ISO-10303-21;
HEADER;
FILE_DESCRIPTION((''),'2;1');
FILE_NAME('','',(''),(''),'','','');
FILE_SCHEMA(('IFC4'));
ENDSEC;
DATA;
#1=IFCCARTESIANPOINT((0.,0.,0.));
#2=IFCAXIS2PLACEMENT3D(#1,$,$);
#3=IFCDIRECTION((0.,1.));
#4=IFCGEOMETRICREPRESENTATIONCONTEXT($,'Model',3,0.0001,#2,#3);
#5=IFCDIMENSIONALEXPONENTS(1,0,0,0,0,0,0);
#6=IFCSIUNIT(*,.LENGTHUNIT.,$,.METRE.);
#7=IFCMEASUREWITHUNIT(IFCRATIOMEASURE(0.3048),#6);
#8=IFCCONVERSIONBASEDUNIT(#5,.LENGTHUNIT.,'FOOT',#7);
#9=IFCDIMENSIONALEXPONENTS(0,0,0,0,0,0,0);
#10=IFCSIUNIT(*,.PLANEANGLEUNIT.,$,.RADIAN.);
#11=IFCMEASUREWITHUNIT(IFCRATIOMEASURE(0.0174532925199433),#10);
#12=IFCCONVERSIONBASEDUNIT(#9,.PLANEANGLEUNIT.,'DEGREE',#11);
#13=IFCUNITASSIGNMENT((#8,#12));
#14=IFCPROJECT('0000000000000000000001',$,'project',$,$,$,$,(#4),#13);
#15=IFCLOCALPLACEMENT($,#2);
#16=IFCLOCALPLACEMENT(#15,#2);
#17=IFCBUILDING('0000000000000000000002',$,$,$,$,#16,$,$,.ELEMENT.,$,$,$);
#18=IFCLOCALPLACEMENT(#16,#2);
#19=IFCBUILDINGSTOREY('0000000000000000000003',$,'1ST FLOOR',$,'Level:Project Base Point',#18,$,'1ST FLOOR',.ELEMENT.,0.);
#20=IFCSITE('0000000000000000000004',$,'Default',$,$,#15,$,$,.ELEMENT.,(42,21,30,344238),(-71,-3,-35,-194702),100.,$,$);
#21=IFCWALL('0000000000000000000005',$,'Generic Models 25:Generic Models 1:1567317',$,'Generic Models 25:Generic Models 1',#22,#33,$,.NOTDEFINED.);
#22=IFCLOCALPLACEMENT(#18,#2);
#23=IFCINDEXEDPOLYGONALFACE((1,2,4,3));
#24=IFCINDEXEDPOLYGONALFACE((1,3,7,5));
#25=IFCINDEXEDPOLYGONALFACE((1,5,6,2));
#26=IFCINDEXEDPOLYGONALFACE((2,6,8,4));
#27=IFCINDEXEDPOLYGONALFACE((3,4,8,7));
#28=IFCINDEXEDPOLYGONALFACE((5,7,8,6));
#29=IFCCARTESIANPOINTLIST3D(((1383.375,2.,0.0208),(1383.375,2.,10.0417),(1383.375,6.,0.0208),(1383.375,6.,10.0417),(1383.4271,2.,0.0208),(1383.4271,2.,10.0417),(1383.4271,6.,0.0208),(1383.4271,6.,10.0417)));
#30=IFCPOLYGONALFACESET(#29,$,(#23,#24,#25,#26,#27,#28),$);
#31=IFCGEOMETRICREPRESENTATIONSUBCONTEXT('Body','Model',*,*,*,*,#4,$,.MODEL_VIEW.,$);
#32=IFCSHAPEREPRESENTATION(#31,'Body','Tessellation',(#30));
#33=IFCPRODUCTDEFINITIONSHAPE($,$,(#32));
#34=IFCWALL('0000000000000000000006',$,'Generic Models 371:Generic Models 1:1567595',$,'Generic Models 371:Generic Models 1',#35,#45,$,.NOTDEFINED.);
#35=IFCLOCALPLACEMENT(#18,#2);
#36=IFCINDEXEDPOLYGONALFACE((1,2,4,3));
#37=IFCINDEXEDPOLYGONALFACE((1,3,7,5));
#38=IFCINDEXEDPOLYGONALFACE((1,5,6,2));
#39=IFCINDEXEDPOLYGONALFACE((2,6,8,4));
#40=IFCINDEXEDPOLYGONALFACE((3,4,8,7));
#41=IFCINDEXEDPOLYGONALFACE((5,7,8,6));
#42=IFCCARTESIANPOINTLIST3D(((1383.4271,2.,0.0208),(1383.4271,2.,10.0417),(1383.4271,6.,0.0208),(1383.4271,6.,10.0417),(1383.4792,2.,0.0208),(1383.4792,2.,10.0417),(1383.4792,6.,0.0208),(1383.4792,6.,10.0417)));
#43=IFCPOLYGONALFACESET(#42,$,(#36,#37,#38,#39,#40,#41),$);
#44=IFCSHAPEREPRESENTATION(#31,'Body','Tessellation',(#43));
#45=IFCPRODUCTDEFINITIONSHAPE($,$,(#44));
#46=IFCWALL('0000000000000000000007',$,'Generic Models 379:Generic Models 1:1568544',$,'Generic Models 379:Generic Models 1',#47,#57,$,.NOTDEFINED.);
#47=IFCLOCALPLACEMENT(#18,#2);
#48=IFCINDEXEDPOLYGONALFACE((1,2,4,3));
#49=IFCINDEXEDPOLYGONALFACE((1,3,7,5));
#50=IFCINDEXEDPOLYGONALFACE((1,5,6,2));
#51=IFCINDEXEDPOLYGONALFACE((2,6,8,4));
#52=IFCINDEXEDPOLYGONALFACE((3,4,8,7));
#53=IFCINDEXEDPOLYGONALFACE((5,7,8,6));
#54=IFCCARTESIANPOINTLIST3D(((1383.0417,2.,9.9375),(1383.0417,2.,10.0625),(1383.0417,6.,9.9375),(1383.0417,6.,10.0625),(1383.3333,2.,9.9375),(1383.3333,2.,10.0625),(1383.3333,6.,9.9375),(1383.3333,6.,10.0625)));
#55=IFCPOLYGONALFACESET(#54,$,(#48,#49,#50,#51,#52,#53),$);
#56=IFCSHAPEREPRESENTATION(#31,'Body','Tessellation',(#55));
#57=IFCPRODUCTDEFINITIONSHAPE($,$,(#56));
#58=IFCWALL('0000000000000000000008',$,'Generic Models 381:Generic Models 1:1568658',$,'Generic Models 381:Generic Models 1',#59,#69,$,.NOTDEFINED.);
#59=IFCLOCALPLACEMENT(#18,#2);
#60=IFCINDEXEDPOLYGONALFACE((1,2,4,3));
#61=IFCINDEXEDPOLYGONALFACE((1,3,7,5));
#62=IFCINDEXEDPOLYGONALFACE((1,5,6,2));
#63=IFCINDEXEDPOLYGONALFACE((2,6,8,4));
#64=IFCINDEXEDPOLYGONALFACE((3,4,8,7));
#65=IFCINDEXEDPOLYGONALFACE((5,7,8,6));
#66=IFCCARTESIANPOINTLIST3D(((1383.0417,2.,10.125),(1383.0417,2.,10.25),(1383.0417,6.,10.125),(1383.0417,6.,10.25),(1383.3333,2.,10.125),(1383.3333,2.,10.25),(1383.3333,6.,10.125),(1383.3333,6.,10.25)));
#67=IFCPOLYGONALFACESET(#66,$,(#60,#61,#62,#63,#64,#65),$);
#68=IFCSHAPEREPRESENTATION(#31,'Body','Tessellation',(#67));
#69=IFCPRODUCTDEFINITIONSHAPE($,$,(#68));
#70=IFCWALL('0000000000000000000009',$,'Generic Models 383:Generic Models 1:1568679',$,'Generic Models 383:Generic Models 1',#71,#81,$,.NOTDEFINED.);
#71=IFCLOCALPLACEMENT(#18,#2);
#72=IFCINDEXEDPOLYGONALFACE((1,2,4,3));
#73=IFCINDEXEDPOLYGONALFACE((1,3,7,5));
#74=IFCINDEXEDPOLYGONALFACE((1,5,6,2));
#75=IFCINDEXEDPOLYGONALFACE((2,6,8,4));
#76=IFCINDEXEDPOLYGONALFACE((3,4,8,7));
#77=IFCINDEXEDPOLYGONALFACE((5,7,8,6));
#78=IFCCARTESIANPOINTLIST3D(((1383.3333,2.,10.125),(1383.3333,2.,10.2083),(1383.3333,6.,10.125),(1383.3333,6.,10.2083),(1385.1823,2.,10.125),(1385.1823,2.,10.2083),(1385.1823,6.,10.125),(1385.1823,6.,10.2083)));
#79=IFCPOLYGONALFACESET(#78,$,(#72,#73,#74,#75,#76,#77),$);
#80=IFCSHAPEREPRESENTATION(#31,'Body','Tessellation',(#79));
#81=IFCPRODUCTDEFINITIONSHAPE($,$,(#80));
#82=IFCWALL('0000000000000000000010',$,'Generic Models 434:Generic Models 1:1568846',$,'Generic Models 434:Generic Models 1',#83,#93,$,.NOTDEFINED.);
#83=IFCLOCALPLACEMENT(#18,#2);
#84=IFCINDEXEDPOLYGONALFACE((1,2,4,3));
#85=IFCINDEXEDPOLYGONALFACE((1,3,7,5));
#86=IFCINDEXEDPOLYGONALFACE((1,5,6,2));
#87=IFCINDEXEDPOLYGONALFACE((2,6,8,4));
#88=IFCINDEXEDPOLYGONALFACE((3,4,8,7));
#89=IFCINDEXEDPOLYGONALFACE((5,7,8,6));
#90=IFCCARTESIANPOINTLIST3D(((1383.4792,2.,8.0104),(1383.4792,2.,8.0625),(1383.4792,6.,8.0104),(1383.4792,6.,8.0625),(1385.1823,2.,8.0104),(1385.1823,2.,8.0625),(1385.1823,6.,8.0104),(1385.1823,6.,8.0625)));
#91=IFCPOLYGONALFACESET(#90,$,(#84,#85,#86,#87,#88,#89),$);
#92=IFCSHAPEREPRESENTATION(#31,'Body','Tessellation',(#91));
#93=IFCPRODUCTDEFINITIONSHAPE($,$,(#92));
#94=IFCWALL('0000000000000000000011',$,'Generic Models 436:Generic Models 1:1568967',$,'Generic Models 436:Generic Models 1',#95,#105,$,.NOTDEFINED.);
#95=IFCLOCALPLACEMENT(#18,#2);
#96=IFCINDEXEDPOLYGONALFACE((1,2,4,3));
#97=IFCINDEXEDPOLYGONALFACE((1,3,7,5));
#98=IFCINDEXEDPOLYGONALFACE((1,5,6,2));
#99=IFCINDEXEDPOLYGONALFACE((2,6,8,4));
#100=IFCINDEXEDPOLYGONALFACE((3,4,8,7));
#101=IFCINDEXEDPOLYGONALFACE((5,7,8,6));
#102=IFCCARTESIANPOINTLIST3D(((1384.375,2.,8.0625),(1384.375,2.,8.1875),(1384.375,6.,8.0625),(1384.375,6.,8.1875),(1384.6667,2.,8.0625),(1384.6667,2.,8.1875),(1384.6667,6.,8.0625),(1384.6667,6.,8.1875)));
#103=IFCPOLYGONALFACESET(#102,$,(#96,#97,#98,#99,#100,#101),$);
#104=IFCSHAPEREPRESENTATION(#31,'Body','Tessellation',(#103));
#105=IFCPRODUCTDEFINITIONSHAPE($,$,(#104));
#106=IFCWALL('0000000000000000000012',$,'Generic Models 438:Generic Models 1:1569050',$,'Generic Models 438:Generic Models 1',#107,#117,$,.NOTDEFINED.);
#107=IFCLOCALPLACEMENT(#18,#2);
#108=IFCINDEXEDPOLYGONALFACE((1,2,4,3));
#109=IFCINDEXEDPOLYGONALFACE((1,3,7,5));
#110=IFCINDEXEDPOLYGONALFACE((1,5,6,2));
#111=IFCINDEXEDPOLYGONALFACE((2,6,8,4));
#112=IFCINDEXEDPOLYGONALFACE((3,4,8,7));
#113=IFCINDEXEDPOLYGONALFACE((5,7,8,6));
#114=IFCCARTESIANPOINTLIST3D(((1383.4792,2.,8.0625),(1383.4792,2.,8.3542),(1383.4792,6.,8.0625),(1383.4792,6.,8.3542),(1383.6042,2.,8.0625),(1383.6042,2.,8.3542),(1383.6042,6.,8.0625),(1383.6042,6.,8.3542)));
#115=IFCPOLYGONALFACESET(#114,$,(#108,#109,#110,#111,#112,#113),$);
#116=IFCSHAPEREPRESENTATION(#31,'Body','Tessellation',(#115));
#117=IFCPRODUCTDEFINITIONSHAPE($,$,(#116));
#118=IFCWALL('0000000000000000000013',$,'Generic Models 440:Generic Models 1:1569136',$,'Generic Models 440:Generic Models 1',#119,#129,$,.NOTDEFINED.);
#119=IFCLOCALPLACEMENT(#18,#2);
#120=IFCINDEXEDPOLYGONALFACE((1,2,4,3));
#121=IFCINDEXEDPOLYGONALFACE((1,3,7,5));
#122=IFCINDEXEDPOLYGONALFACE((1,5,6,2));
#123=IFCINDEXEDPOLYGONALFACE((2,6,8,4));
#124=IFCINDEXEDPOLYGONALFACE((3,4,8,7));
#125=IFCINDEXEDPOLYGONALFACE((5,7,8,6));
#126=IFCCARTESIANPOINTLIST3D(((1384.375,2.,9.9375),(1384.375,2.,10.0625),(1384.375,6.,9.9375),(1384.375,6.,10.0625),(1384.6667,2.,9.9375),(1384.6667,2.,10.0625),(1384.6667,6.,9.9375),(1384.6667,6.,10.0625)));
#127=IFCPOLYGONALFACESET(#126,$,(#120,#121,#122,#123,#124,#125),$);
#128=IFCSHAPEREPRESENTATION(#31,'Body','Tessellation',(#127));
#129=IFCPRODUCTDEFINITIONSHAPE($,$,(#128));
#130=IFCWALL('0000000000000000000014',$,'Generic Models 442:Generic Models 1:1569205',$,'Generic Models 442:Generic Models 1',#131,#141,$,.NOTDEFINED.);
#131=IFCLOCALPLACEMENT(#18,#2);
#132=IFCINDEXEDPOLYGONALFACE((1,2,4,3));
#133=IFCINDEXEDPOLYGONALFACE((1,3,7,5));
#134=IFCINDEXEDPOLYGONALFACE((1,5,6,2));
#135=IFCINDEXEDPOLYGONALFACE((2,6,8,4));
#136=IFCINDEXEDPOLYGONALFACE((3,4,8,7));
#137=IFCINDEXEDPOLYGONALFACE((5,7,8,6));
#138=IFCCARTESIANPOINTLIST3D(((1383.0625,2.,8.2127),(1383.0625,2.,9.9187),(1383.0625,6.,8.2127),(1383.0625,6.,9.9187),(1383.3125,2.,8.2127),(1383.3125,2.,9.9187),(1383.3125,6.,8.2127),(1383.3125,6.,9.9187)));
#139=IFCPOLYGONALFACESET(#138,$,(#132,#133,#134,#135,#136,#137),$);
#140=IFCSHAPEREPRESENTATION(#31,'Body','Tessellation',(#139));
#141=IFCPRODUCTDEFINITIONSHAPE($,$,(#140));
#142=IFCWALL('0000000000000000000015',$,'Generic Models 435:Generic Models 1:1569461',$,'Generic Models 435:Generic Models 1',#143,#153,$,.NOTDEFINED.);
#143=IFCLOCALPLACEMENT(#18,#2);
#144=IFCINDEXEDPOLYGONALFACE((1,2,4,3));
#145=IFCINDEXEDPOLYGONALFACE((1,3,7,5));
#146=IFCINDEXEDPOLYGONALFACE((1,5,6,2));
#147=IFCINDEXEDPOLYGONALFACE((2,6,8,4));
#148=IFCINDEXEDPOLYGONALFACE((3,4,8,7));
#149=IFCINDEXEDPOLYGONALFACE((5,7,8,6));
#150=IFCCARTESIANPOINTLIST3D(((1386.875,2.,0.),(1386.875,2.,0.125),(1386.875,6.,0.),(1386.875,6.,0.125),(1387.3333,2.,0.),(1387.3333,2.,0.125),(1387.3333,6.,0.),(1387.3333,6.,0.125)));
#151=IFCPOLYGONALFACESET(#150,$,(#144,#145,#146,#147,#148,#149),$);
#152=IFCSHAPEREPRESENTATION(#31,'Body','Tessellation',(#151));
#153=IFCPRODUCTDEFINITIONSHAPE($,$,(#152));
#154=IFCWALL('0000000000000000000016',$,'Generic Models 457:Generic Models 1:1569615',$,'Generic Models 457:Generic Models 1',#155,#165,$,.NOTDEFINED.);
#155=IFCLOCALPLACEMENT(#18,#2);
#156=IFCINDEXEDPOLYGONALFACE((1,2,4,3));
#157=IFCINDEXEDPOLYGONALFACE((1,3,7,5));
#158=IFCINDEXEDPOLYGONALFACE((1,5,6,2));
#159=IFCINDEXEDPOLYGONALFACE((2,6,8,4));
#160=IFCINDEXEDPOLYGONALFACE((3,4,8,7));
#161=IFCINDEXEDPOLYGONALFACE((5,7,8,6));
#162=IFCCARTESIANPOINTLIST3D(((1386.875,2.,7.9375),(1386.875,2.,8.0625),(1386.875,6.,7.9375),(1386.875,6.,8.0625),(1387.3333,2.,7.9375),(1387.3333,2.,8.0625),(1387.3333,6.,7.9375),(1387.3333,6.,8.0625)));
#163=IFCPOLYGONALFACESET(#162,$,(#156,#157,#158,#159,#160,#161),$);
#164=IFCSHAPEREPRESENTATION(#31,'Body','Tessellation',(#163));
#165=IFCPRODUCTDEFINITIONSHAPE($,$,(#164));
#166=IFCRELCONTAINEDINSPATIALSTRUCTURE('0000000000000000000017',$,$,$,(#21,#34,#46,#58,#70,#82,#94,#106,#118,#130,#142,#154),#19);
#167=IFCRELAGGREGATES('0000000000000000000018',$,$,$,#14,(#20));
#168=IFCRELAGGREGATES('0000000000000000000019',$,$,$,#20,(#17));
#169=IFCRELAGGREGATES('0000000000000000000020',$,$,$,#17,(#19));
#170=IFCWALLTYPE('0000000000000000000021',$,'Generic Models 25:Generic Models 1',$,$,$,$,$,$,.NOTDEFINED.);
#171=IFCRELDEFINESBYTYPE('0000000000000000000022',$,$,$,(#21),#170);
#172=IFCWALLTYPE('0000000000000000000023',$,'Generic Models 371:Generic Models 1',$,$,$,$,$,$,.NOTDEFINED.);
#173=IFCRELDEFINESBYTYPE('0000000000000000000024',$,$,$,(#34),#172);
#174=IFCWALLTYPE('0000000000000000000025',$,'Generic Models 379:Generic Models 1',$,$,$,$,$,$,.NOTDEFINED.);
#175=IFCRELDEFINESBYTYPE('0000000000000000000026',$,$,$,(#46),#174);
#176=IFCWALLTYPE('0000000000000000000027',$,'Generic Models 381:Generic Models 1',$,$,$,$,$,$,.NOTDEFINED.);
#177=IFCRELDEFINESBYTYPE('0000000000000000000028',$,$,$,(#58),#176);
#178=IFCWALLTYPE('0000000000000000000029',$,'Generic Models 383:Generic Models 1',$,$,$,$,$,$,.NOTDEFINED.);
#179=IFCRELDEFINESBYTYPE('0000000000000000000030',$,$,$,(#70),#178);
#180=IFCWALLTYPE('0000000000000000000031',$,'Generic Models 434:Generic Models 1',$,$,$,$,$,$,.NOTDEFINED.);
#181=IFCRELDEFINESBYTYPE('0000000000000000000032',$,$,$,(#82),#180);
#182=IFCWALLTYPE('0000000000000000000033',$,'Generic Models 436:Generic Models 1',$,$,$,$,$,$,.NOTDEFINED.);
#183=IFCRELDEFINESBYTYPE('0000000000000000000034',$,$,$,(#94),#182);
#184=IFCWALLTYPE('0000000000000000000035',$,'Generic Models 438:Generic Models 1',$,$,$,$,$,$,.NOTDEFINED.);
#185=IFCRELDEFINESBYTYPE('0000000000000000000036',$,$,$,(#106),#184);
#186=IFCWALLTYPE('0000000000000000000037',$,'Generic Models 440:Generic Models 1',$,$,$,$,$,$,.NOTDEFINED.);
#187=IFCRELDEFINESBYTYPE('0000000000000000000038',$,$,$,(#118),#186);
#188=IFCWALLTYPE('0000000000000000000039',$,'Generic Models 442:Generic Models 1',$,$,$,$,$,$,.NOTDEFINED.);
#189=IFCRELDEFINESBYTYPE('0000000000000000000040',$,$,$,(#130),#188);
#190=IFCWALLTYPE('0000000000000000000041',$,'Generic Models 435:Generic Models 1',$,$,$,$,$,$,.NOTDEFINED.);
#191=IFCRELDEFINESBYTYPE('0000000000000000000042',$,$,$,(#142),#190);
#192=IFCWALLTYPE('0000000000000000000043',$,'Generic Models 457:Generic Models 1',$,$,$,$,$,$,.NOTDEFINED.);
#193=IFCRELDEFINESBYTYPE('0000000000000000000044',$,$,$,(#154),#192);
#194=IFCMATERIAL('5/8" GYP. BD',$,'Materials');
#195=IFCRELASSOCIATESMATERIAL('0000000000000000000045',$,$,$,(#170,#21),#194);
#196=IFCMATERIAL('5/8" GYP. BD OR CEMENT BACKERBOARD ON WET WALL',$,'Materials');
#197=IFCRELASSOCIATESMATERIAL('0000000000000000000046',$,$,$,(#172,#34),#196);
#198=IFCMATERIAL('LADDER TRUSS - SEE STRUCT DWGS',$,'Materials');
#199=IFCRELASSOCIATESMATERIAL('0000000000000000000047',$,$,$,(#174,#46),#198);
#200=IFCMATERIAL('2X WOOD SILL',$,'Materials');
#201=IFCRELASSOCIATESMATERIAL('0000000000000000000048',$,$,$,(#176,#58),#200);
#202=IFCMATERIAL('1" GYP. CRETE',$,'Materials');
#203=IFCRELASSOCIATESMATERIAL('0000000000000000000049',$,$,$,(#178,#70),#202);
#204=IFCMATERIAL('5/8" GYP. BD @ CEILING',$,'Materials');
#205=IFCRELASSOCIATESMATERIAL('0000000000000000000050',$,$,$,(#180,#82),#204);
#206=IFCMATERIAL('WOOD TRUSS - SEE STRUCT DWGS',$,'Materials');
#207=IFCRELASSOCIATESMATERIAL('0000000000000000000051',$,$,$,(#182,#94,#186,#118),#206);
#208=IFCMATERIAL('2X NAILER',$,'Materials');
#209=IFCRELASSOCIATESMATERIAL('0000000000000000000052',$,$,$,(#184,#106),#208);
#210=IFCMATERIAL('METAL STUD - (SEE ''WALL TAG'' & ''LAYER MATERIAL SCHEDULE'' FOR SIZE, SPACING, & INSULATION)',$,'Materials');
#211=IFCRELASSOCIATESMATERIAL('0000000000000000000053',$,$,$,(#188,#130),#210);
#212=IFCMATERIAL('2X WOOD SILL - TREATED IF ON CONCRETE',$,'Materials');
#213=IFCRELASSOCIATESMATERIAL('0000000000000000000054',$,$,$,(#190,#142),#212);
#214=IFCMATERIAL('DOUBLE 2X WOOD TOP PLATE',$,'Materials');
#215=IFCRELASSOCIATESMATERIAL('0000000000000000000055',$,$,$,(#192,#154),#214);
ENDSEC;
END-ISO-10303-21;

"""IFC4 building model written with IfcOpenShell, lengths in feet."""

from ifc_helpers import new_model, entity, si_unit, converted_unit, direction, frame, frame_2d, origin, origin_2d_with_axis, place, context, subcontext, project, spatial, rectangle, extrude, material, type_object, element, save


model = new_model("IFC4")

# Units and contexts
model_context = context("Model", 3, precision=0.0001, world=origin(), true_north=direction((0.0, 1.0)))
body_context = subcontext(model_context, "Body", "Model", "MODEL_VIEW")
ifc_project = project(units=[converted_unit("LENGTHUNIT", "FOOT", entity("IfcRatioMeasure", 0.3048), si_unit("LENGTHUNIT", "METRE"), dimensions=[1, 0, 0, 0, 0, 0, 0]), converted_unit("PLANEANGLEUNIT", "DEGREE", entity("IfcRatioMeasure", 0.0174532925199433), si_unit("PLANEANGLEUNIT", "RADIAN"), dimensions=[0, 0, 0, 0, 0, 0, 0])], contexts=[model_context])

# Site, building, storey
site_placement = place(None, origin())
site = spatial("IfcSite", under=ifc_project, at=site_placement, Name="Default", CompositionType="ELEMENT", RefLatitude=(42, 21, 30, 344238), RefLongitude=(-71, -3, -35, -194702), RefElevation=100.0)
building_placement = place(site_placement, origin())
building = spatial("IfcBuilding", under=site, at=building_placement, CompositionType="ELEMENT")
storey_placement = place(building_placement, origin())
storey = spatial("IfcBuildingStorey", under=building, at=storey_placement, Name="1ST FLOOR", ObjectType="Level:Project Base Point", LongName="1ST FLOOR", CompositionType="ELEMENT", Elevation=0.0)

# Walls
ifc_material_1 = material(Name="5/8\" GYP. BD", Category="Materials")
wall_type_1 = type_object("IfcWallType", Name="Generic Models 25:Generic Models 1", PredefinedType="NOTDEFINED", material=ifc_material_1)
wall_1_placement = place(storey_placement, frame((1383.375, 2.0, 0.0208), z_axis=(0.0, 0.0, 1.0), x_axis=(0.0, 1.0, 0.0)))
element("IfcWall", 1, at=wall_1_placement, inside=storey, type_object=wall_type_1, material=ifc_material_1, Name="Generic Models 25:Generic Models 1:1567317", ObjectType="Generic Models 25:Generic Models 1", PredefinedType="NOTDEFINED", context=body_context, shape_type="SweptSolid", body=[
    extrude(rectangle(XDim=4.0, YDim=0.0521, at=origin_2d_with_axis()), frame((2.0, -0.026, 0.0)), (0.0, 0.0, 1.0), 10.0208),
])
ifc_material_2 = material(Name="5/8\" GYP. BD OR CEMENT BACKERBOARD ON WET WALL", Category="Materials")
wall_type_2 = type_object("IfcWallType", Name="Generic Models 371:Generic Models 1", PredefinedType="NOTDEFINED", material=ifc_material_2)
wall_2_placement = place(storey_placement, frame((1383.4271, 2.0, 0.0208), z_axis=(0.0, 0.0, 1.0), x_axis=(0.0, 1.0, 0.0)))
element("IfcWall", 2, at=wall_2_placement, inside=storey, type_object=wall_type_2, material=ifc_material_2, Name="Generic Models 371:Generic Models 1:1567595", ObjectType="Generic Models 371:Generic Models 1", PredefinedType="NOTDEFINED", context=body_context, shape_type="SweptSolid", body=[
    extrude(rectangle(XDim=4.0, YDim=0.0521, at=frame_2d((0.0, 0.0), x_axis=(1.0, 0.0))), frame((2.0, -0.026, 0.0)), (0.0, 0.0, 1.0), 10.0208),
])
ifc_material_3 = material(Name="LADDER TRUSS - SEE STRUCT DWGS", Category="Materials")
wall_type_3 = type_object("IfcWallType", Name="Generic Models 379:Generic Models 1", PredefinedType="NOTDEFINED", material=ifc_material_3)
wall_3_placement = place(storey_placement, frame((1383.0417, 2.0, 9.9375), z_axis=(0.0, 0.0, 1.0), x_axis=(0.0, 1.0, 0.0)))
element("IfcWall", 3, at=wall_3_placement, inside=storey, type_object=wall_type_3, material=ifc_material_3, Name="Generic Models 379:Generic Models 1:1568544", ObjectType="Generic Models 379:Generic Models 1", PredefinedType="NOTDEFINED", context=body_context, shape_type="SweptSolid", body=[
    extrude(rectangle(XDim=4.0, YDim=0.2917, at=origin_2d_with_axis()), frame((2.0, -0.1458, 0.0)), (0.0, 0.0, 1.0), 0.125),
])
ifc_material_4 = material(Name="2X WOOD SILL", Category="Materials")
wall_type_4 = type_object("IfcWallType", Name="Generic Models 381:Generic Models 1", PredefinedType="NOTDEFINED", material=ifc_material_4)
wall_4_placement = place(storey_placement, frame((1383.0417, 2.0, 10.125), z_axis=(0.0, 0.0, 1.0), x_axis=(0.0, 1.0, 0.0)))
element("IfcWall", 4, at=wall_4_placement, inside=storey, type_object=wall_type_4, material=ifc_material_4, Name="Generic Models 381:Generic Models 1:1568658", ObjectType="Generic Models 381:Generic Models 1", PredefinedType="NOTDEFINED", context=body_context, shape_type="SweptSolid", body=[
    extrude(rectangle(XDim=4.0, YDim=0.2917, at=frame_2d((0.0, 0.0), x_axis=(1.0, 0.0))), frame((2.0, -0.1458, 0.0)), (0.0, 0.0, 1.0), 0.125),
])
ifc_material_5 = material(Name="1\" GYP. CRETE", Category="Materials")
wall_type_5 = type_object("IfcWallType", Name="Generic Models 383:Generic Models 1", PredefinedType="NOTDEFINED", material=ifc_material_5)
wall_5_placement = place(storey_placement, frame((1383.3333, 2.0, 10.125), z_axis=(0.0, 0.0, 1.0), x_axis=(0.0, 1.0, 0.0)))
element("IfcWall", 5, at=wall_5_placement, inside=storey, type_object=wall_type_5, material=ifc_material_5, Name="Generic Models 383:Generic Models 1:1568679", ObjectType="Generic Models 383:Generic Models 1", PredefinedType="NOTDEFINED", context=body_context, shape_type="SweptSolid", body=[
    extrude(rectangle(XDim=4.0, YDim=1.849, at=frame_2d((0.0, 0.0), x_axis=(1.0, 0.0))), frame((2.0, -0.9245, 0.0)), (0.0, 0.0, 1.0), 0.0833),
])
ifc_material_6 = material(Name="5/8\" GYP. BD @ CEILING", Category="Materials")
wall_type_6 = type_object("IfcWallType", Name="Generic Models 434:Generic Models 1", PredefinedType="NOTDEFINED", material=ifc_material_6)
wall_6_placement = place(storey_placement, frame((1383.4792, 2.0, 8.0104), z_axis=(0.0, 0.0, 1.0), x_axis=(0.0, 1.0, 0.0)))
element("IfcWall", 6, at=wall_6_placement, inside=storey, type_object=wall_type_6, material=ifc_material_6, Name="Generic Models 434:Generic Models 1:1568846", ObjectType="Generic Models 434:Generic Models 1", PredefinedType="NOTDEFINED", context=body_context, shape_type="SweptSolid", body=[
    extrude(rectangle(XDim=4.0, YDim=1.7031, at=frame_2d((0.0, 0.0), x_axis=(1.0, 0.0))), frame((2.0, -0.8516, 0.0)), (0.0, 0.0, 1.0), 0.0521),
])
ifc_material_7 = material(Name="WOOD TRUSS - SEE STRUCT DWGS", Category="Materials")
wall_type_7 = type_object("IfcWallType", Name="Generic Models 436:Generic Models 1", PredefinedType="NOTDEFINED", material=ifc_material_7)
wall_7_placement = place(storey_placement, frame((1384.375, 2.0, 8.0625), z_axis=(0.0, 0.0, 1.0), x_axis=(0.0, 1.0, 0.0)))
element("IfcWall", 7, at=wall_7_placement, inside=storey, type_object=wall_type_7, material=ifc_material_7, Name="Generic Models 436:Generic Models 1:1568967", ObjectType="Generic Models 436:Generic Models 1", PredefinedType="NOTDEFINED", context=body_context, shape_type="SweptSolid", body=[
    extrude(rectangle(XDim=4.0, YDim=0.2917, at=frame_2d((0.0, 0.0), x_axis=(1.0, 0.0))), frame((2.0, -0.1458, 0.0)), (0.0, 0.0, 1.0), 0.125),
])
ifc_material_8 = material(Name="2X NAILER", Category="Materials")
wall_type_8 = type_object("IfcWallType", Name="Generic Models 438:Generic Models 1", PredefinedType="NOTDEFINED", material=ifc_material_8)
wall_8_placement = place(storey_placement, frame((1383.4792, 2.0, 8.0625), z_axis=(0.0, 0.0, 1.0), x_axis=(0.0, 1.0, 0.0)))
element("IfcWall", 8, at=wall_8_placement, inside=storey, type_object=wall_type_8, material=ifc_material_8, Name="Generic Models 438:Generic Models 1:1569050", ObjectType="Generic Models 438:Generic Models 1", PredefinedType="NOTDEFINED", context=body_context, shape_type="SweptSolid", body=[
    extrude(rectangle(XDim=4.0, YDim=0.125, at=frame_2d((0.0, 0.0), x_axis=(1.0, 0.0))), frame((2.0, -0.0625, 0.0)), (0.0, 0.0, 1.0), 0.2917),
])
wall_type_9 = type_object("IfcWallType", Name="Generic Models 440:Generic Models 1", PredefinedType="NOTDEFINED", material=ifc_material_7)
wall_9_placement = place(storey_placement, frame((1384.375, 2.0, 9.9375), z_axis=(0.0, 0.0, 1.0), x_axis=(0.0, 1.0, 0.0)))
element("IfcWall", 9, at=wall_9_placement, inside=storey, type_object=wall_type_9, material=ifc_material_7, Name="Generic Models 440:Generic Models 1:1569136", ObjectType="Generic Models 440:Generic Models 1", PredefinedType="NOTDEFINED", context=body_context, shape_type="SweptSolid", body=[
    extrude(rectangle(XDim=4.0, YDim=0.2917, at=frame_2d((0.0, 0.0), x_axis=(1.0, 0.0))), frame((2.0, -0.1458, 0.0)), (0.0, 0.0, 1.0), 0.125),
])
ifc_material_9 = material(Name="METAL STUD - (SEE 'WALL TAG' & 'LAYER MATERIAL SCHEDULE' FOR SIZE, SPACING, & INSULATION)", Category="Materials")
wall_type_10 = type_object("IfcWallType", Name="Generic Models 442:Generic Models 1", PredefinedType="NOTDEFINED", material=ifc_material_9)
wall_10_placement = place(storey_placement, frame((1383.0625, 2.0, 8.2127), z_axis=(0.0, 0.0, 1.0), x_axis=(0.0, 1.0, 0.0)))
element("IfcWall", 10, at=wall_10_placement, inside=storey, type_object=wall_type_10, material=ifc_material_9, Name="Generic Models 442:Generic Models 1:1569205", ObjectType="Generic Models 442:Generic Models 1", PredefinedType="NOTDEFINED", context=body_context, shape_type="SweptSolid", body=[
    extrude(rectangle(XDim=4.0, YDim=0.25, at=origin_2d_with_axis()), frame((2.0, -0.125, 0.0)), (0.0, 0.0, 1.0), 1.706),
])
ifc_material_10 = material(Name="2X WOOD SILL - TREATED IF ON CONCRETE", Category="Materials")
wall_type_11 = type_object("IfcWallType", Name="Generic Models 435:Generic Models 1", PredefinedType="NOTDEFINED", material=ifc_material_10)
wall_11_placement = place(storey_placement, frame((1386.875, 2.0, 0.0), z_axis=(0.0, 0.0, 1.0), x_axis=(0.0, 1.0, 0.0)))
element("IfcWall", 11, at=wall_11_placement, inside=storey, type_object=wall_type_11, material=ifc_material_10, Name="Generic Models 435:Generic Models 1:1569461", ObjectType="Generic Models 435:Generic Models 1", PredefinedType="NOTDEFINED", context=body_context, shape_type="SweptSolid", body=[
    extrude(rectangle(XDim=4.0, YDim=0.4583, at=frame_2d((0.0, 0.0), x_axis=(1.0, 0.0))), frame((2.0, -0.2292, 0.0)), (0.0, 0.0, 1.0), 0.125),
])
ifc_material_11 = material(Name="DOUBLE 2X WOOD TOP PLATE", Category="Materials")
wall_type_12 = type_object("IfcWallType", Name="Generic Models 457:Generic Models 1", PredefinedType="NOTDEFINED", material=ifc_material_11)
wall_12_placement = place(storey_placement, frame((1386.875, 2.0, 7.9375), z_axis=(0.0, 0.0, 1.0), x_axis=(0.0, 1.0, 0.0)))
element("IfcWall", 12, at=wall_12_placement, inside=storey, type_object=wall_type_12, material=ifc_material_11, Name="Generic Models 457:Generic Models 1:1569615", ObjectType="Generic Models 457:Generic Models 1", PredefinedType="NOTDEFINED", context=body_context, shape_type="SweptSolid", body=[
    extrude(rectangle(XDim=4.0, YDim=0.4583, at=frame_2d((0.0, 0.0), x_axis=(1.0, 0.0))), frame((2.0, -0.2292, 0.0)), (0.0, 0.0, 1.0), 0.125),
])

save(model, "model.ifc")
